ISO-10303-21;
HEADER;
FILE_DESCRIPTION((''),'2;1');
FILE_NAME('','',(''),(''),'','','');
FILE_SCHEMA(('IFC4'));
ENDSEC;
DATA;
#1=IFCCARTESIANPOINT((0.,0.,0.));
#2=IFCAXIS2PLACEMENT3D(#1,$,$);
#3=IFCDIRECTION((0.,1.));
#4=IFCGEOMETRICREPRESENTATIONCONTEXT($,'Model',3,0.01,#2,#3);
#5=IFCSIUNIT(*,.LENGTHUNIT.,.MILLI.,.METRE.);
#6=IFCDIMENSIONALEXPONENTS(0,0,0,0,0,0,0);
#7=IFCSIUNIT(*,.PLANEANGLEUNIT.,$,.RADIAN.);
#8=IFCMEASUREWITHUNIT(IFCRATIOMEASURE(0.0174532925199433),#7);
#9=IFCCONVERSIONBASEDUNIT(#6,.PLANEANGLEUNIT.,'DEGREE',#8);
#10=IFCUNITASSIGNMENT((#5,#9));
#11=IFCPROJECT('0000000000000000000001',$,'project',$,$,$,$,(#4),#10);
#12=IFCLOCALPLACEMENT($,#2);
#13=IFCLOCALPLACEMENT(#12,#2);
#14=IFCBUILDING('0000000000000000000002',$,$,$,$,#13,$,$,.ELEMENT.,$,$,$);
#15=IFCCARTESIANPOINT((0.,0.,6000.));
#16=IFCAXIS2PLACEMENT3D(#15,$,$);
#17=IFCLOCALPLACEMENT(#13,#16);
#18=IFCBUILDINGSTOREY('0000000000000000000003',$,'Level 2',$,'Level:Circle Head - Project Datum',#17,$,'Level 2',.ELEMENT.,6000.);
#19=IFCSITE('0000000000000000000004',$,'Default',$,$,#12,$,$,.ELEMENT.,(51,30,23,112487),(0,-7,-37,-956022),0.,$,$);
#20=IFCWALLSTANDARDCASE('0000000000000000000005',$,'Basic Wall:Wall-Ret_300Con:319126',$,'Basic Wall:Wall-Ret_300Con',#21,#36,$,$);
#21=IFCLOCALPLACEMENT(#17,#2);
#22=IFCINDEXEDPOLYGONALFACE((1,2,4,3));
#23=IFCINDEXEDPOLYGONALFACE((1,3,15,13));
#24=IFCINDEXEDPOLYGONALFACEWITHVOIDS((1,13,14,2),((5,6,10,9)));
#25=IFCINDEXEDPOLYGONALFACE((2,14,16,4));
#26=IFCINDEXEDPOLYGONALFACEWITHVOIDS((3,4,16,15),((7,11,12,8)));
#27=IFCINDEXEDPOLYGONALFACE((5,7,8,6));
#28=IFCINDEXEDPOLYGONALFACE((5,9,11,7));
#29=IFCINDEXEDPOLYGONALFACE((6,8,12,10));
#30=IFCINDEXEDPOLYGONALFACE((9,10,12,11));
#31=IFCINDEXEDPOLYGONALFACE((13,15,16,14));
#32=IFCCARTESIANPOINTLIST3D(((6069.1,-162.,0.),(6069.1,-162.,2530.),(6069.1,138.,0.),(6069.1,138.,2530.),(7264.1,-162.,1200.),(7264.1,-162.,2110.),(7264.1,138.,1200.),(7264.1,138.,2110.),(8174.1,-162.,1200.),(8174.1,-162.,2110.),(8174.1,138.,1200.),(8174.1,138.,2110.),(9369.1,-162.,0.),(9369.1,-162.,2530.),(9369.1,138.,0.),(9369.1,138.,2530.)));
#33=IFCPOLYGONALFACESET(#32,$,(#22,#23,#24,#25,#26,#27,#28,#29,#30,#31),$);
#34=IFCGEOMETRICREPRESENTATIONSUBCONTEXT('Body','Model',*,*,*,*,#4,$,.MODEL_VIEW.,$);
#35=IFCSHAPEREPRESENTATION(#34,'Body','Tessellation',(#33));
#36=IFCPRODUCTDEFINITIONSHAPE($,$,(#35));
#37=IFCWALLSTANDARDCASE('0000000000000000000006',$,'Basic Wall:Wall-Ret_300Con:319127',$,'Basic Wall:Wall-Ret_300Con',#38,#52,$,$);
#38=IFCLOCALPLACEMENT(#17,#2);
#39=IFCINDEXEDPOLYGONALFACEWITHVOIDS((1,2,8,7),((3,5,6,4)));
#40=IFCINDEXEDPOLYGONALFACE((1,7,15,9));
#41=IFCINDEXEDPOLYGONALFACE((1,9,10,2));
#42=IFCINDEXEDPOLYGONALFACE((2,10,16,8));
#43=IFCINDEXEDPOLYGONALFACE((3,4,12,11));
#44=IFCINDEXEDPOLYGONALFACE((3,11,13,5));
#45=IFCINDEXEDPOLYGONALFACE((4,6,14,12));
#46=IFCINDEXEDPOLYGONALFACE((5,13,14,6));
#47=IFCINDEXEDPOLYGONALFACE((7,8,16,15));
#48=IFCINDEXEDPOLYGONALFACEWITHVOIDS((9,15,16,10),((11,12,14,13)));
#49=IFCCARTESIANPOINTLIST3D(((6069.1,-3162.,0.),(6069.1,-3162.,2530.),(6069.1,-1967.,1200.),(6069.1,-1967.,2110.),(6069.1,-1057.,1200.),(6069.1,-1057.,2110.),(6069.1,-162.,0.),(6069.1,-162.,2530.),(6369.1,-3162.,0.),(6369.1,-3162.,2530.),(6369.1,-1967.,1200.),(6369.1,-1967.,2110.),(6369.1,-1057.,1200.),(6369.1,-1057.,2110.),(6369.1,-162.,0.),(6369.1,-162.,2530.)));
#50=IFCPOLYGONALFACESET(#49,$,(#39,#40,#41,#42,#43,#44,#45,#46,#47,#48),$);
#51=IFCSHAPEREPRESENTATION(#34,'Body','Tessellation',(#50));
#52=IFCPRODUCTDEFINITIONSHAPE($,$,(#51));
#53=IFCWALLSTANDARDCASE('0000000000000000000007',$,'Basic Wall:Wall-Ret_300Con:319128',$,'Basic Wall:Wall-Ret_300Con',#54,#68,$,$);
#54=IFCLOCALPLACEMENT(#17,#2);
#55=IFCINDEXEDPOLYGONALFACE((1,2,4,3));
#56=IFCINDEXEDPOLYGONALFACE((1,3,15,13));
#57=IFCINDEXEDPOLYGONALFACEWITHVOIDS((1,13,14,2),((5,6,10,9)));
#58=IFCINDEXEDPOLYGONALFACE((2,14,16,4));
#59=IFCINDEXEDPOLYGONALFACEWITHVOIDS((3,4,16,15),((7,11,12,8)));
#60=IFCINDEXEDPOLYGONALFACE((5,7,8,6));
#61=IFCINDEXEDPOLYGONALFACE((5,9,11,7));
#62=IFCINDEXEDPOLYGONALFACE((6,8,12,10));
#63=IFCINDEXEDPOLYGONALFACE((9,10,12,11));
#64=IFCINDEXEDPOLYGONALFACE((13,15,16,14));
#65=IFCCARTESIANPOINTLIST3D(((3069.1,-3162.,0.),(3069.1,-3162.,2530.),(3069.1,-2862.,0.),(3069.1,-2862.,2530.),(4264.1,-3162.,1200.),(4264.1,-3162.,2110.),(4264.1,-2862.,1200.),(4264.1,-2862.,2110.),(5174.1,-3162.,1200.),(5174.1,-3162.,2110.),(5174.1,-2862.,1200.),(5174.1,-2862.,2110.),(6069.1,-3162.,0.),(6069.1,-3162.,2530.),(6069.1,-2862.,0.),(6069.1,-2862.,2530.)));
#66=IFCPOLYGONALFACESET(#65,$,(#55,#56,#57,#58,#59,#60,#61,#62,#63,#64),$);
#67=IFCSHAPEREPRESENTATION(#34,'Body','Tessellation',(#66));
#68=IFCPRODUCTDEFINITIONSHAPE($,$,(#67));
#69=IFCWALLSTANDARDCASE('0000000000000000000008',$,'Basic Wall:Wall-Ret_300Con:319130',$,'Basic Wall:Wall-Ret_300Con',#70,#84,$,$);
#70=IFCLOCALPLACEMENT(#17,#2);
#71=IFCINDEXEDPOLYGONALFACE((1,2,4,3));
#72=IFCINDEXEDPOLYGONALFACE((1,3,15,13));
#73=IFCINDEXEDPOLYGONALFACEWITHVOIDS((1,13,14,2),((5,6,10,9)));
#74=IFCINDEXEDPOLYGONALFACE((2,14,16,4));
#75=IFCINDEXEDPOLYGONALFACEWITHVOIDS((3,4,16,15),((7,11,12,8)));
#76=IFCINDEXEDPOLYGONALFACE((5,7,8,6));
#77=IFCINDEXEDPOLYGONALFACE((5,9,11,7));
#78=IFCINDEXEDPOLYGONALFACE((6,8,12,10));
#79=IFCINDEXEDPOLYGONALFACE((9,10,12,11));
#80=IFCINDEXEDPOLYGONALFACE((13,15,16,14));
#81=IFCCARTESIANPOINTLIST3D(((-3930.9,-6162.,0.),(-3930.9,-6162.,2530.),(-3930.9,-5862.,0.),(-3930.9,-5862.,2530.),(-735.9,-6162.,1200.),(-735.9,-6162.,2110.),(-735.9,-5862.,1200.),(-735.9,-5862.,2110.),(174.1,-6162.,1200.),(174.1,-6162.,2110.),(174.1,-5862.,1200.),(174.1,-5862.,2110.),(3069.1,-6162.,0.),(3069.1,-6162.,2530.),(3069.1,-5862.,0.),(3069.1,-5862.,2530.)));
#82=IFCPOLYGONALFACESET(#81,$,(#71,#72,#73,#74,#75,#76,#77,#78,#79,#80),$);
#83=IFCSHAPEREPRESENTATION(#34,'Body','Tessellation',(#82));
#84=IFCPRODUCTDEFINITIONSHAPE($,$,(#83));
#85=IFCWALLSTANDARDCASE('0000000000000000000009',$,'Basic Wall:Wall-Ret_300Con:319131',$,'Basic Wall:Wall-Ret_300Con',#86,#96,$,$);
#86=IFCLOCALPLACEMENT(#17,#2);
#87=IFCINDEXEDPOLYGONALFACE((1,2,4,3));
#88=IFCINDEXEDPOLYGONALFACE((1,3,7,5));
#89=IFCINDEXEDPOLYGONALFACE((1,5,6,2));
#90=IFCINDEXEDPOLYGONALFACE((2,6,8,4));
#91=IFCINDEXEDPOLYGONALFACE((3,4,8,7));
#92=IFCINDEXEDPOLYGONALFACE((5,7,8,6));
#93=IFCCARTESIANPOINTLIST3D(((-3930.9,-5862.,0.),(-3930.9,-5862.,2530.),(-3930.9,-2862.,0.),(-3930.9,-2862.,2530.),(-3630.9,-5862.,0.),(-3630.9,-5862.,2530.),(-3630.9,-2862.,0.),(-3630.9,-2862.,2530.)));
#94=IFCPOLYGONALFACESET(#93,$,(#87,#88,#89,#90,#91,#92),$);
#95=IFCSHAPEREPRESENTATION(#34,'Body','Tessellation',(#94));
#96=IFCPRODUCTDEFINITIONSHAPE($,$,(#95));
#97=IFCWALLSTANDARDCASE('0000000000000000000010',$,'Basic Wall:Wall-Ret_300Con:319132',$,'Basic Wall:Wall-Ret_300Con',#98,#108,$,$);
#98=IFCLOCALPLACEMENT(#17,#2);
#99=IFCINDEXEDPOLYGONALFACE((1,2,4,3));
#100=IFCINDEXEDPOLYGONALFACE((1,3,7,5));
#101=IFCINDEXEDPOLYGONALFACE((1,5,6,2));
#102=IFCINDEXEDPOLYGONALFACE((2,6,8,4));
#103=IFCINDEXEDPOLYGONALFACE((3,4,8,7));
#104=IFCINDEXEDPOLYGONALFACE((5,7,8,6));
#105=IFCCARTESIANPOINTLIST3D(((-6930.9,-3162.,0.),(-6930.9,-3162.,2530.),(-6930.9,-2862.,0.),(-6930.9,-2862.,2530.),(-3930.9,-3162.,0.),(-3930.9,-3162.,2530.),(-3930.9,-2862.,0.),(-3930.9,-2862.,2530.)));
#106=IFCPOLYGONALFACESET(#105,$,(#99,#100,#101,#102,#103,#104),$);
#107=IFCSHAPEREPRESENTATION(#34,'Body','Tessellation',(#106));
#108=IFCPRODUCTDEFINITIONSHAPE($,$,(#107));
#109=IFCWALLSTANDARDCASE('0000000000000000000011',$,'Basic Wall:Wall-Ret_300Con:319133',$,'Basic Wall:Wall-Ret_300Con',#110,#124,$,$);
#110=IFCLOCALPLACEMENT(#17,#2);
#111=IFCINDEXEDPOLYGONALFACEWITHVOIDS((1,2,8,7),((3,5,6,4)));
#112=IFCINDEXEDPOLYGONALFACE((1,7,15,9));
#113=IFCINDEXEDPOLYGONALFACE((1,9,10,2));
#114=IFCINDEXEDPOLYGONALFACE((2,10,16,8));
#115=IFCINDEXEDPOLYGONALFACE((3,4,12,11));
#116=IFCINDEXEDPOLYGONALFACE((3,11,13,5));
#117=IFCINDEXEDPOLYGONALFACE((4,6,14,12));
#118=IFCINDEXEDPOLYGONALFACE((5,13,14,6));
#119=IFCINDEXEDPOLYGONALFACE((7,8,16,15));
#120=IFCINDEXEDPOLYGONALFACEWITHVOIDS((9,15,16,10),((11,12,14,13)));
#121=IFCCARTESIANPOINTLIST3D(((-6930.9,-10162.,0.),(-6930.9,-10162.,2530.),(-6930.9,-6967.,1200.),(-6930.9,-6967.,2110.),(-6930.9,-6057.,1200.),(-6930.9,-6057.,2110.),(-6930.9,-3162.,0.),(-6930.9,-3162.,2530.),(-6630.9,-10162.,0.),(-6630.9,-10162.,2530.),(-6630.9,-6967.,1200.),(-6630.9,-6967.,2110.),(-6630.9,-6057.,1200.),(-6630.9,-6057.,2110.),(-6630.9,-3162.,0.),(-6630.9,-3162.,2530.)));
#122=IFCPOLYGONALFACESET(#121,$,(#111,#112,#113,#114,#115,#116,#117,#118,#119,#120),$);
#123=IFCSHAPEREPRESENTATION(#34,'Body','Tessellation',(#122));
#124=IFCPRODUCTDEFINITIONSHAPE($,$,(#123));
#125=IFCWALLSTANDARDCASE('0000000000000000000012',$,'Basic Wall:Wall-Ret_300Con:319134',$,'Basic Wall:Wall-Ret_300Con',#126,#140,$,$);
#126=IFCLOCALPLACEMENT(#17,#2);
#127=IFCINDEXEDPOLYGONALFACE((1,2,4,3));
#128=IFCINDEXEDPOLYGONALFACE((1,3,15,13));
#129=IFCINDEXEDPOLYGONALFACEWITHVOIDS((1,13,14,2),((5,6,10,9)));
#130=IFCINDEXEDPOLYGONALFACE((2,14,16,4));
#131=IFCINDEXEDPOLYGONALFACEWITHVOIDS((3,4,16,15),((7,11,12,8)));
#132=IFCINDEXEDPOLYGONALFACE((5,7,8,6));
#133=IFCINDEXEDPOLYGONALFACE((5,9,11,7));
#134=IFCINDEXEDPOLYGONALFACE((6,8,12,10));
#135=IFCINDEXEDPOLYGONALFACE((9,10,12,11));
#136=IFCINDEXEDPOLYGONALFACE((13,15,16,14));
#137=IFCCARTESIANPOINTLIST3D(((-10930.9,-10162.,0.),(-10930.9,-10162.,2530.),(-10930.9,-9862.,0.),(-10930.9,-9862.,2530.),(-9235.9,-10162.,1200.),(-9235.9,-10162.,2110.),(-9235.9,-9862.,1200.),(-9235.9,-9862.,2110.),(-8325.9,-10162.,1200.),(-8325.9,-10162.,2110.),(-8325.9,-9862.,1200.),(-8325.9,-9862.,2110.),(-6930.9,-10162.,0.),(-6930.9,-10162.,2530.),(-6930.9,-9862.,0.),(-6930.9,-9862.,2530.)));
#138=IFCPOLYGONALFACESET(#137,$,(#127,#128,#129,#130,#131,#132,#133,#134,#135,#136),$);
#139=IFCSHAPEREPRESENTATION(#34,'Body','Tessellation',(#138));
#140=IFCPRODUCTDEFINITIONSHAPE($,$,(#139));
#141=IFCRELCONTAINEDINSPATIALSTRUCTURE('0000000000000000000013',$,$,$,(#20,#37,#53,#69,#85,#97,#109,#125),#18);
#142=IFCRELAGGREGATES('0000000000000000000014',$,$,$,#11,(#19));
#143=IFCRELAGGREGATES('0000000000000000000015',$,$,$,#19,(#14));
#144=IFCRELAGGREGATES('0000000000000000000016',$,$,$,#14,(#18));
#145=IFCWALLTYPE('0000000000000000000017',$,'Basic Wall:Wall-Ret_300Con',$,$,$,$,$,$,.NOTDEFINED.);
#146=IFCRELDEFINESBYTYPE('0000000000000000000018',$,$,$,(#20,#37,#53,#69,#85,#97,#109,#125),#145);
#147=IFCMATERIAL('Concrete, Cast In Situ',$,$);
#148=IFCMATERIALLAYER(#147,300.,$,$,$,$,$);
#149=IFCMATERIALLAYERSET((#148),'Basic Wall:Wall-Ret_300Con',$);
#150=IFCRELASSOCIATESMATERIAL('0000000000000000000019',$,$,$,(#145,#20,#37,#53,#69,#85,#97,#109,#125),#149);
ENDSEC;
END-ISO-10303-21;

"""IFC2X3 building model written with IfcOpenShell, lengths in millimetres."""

from ifc_helpers import new_model, entity, si_unit, converted_unit, direction, frame, frame_2d, origin, place, context, subcontext, project, spatial, polyline, rectangle, extrude, clip, bounded_halfspace, material, layer, layer_set, layer_usage, type_object, element, save


model = new_model("IFC2X3")

# Units and contexts
model_context = context("Model", 3, precision=0.01, world=origin(), true_north=direction((0.0, 1.0)))
body_context = subcontext(model_context, "Body", "Model", "MODEL_VIEW")
ifc_project = project(units=[si_unit("LENGTHUNIT", "METRE", prefix="MILLI"), converted_unit("PLANEANGLEUNIT", "DEGREE", entity("IfcRatioMeasure", 0.0174532925199433), si_unit("PLANEANGLEUNIT", "RADIAN"), dimensions=[0, 0, 0, 0, 0, 0, 0])], contexts=[model_context])

# Site, building, storey
site_placement = place(None, origin())
site = spatial("IfcSite", under=ifc_project, at=site_placement, Name="Default", CompositionType="ELEMENT", RefLatitude=(51, 30, 23, 112487), RefLongitude=(0, -7, -37, -956022), RefElevation=0.0)
building_placement = place(site_placement, origin())
building = spatial("IfcBuilding", under=site, at=building_placement, CompositionType="ELEMENT")
storey_placement = place(building_placement, frame((0.0, 0.0, 6000.0)))
storey = spatial("IfcBuildingStorey", under=building, at=storey_placement, Name="Level 2", ObjectType="Level:Circle Head - Project Datum", LongName="Level 2", CompositionType="ELEMENT", Elevation=6000.0)

# Walls, openings
ifc_material = material(Name="Concrete, Cast In Situ")
ifc_layer = layer(ifc_material, 300.0)
ifc_layer_set = layer_set([ifc_layer], Name="Basic Wall:Wall-Ret_300Con")
ifc_layer_usage_1 = layer_usage(ifc_layer_set, "AXIS2", "NEGATIVE", 150.0)
wall_type = type_object("IfcWallType", Name="Basic Wall:Wall-Ret_300Con", PredefinedType="NOTDEFINED", material=ifc_layer_set)
wall_1_placement = place(storey_placement, frame((9369.1, -12.0, 0.0), z_axis=(0.0, 0.0, 1.0), x_axis=(-1.0, 0.0, 0.0)))
wall_1 = element("IfcWallStandardCase", 1, at=wall_1_placement, inside=storey, type_object=wall_type, material=ifc_layer_usage_1, Name="Basic Wall:Wall-Ret_300Con:319126", ObjectType="Basic Wall:Wall-Ret_300Con", context=body_context, shape_type="Clipping", body=[
    clip(extrude(rectangle(XDim=3300.0, YDim=300.0, at=frame_2d((1650.0, 0.0), x_axis=(-1.0, 0.0))), origin(), (0.0, 0.0, 1.0), 2530.0), bounded_halfspace(frame((19.9, -150.0, 2530.0), z_axis=(0.0, 0.0, -1.0), x_axis=(-1.0, 0.0, 0.0)), True, frame((19.9, -150.0, 2530.0)), polyline([(0.0, 0.0), (280.1, 0.0), (3280.1, 0.0), (3280.1, 300.0), (2980.1, 300.0), (0.0, 300.0), (0.0, 0.0)]))),
])
opening_1_placement = place(wall_1_placement, frame((2105.0, 150.0, 1200.0)))
element("IfcOpeningElement", 2, at=opening_1_placement, cuts=wall_1, ObjectType="Opening", context=body_context, shape_type="SweptSolid", body=[
    extrude(rectangle(XDim=910.0, YDim=910.0, at=frame_2d((455.0, 455.0), x_axis=(-1.0, 0.0))), frame((0.0, 0.0, 0.0), z_axis=(0.0, -1.0, 0.0), x_axis=(0.0, 0.0, 1.0)), (0.0, 0.0, 1.0), 300.0),
])
ifc_layer_usage_2 = layer_usage(ifc_layer_set, "AXIS2", "NEGATIVE", 150.0)
wall_2_placement = place(storey_placement, frame((6219.1, -162.0, 0.0), z_axis=(0.0, 0.0, 1.0), x_axis=(0.0, -1.0, 0.0)))
wall_2 = element("IfcWallStandardCase", 3, at=wall_2_placement, inside=storey, type_object=wall_type, material=ifc_layer_usage_2, Name="Basic Wall:Wall-Ret_300Con:319127", ObjectType="Basic Wall:Wall-Ret_300Con", context=body_context, shape_type="Clipping", body=[
    clip(extrude(rectangle(XDim=3000.0, YDim=300.0, at=frame_2d((1500.0, 0.0), x_axis=(-1.0, 0.0))), origin(), (0.0, 0.0, 1.0), 2530.0), bounded_halfspace(frame((0.0, -150.0, 2530.0), z_axis=(0.0, 0.0, -1.0), x_axis=(0.0, 1.0, 0.0)), True, frame((0.0, -150.0, 2530.0)), polyline([(0.0, 0.0), (2700.0, 0.0), (3000.0, 0.0), (3000.0, 280.1), (5.2, 280.1), (0.0, 280.1), (0.0, 0.0)]))),
])
opening_2_placement = place(wall_2_placement, frame((1805.0, 150.0, 1200.0)))
element("IfcOpeningElement", 4, at=opening_2_placement, cuts=wall_2, ObjectType="Opening", context=body_context, shape_type="SweptSolid", body=[
    extrude(rectangle(XDim=910.0, YDim=910.0, at=frame_2d((455.0, 455.0), x_axis=(-1.0, 0.0))), frame((0.0, 0.0, 0.0), z_axis=(0.0, -1.0, 0.0), x_axis=(0.0, 0.0, 1.0)), (0.0, 0.0, 1.0), 300.0),
])
ifc_layer_usage_3 = layer_usage(ifc_layer_set, "AXIS2", "NEGATIVE", 150.0)
wall_3_placement = place(storey_placement, frame((6069.1, -3012.0, 0.0), z_axis=(0.0, 0.0, 1.0), x_axis=(-1.0, 0.0, 0.0)))
wall_3 = element("IfcWallStandardCase", 5, at=wall_3_placement, inside=storey, type_object=wall_type, material=ifc_layer_usage_3, Name="Basic Wall:Wall-Ret_300Con:319128", ObjectType="Basic Wall:Wall-Ret_300Con", context=body_context, shape_type="Clipping", body=[
    clip(extrude(rectangle(XDim=3000.0, YDim=300.0, at=frame_2d((1500.0, 0.0), x_axis=(-1.0, 0.0))), origin(), (0.0, 0.0, 1.0), 2530.0), bounded_halfspace(frame((0.0, -150.0, 2530.0), z_axis=(0.0, 0.0, -1.0), x_axis=(-1.0, 0.0, 0.0)), True, frame((0.0, -150.0, 2530.0)), polyline([(0.0, 0.0), (3000.0, 0.0), (3000.0, 300.0), (2700.0, 300.0), (0.0, 300.0), (0.0, 0.0)]))),
])
opening_3_placement = place(wall_3_placement, frame((895.0, -150.0, 1200.0)))
element("IfcOpeningElement", 6, at=opening_3_placement, cuts=wall_3, ObjectType="Opening", context=body_context, shape_type="SweptSolid", body=[
    extrude(rectangle(XDim=910.0, YDim=910.0, at=frame_2d((455.0, 455.0), x_axis=(-1.0, 0.0))), frame((0.0, 0.0, 0.0), z_axis=(0.0, 1.0, 0.0), x_axis=(0.0, 0.0, 1.0)), (0.0, 0.0, 1.0), 300.0),
])

# Wall, opening
ifc_layer_usage_4 = layer_usage(ifc_layer_set, "AXIS2", "NEGATIVE", 150.0)
wall_4_placement = place(storey_placement, frame((3069.1, -6012.0, 0.0), z_axis=(0.0, 0.0, 1.0), x_axis=(-1.0, 0.0, 0.0)))
wall_4 = element("IfcWallStandardCase", 7, at=wall_4_placement, inside=storey, type_object=wall_type, material=ifc_layer_usage_4, Name="Basic Wall:Wall-Ret_300Con:319130", ObjectType="Basic Wall:Wall-Ret_300Con", context=body_context, shape_type="Clipping", body=[
    clip(extrude(rectangle(XDim=7000.0, YDim=300.0, at=frame_2d((3500.0, 0.0), x_axis=(-1.0, 0.0))), origin(), (0.0, 0.0, 1.0), 2530.0), bounded_halfspace(frame((0.0, -150.0, 2530.0), z_axis=(0.0, 0.0, -1.0), x_axis=(-1.0, 0.0, 0.0)), True, frame((0.0, -150.0, 2530.0)), polyline([(0.0, 0.0), (6700.0, 0.0), (7000.0, 0.0), (7000.0, 300.0), (0.0, 300.0), (0.0, 0.0)]))),
])
opening_4_placement = place(wall_4_placement, frame((2895.0, -150.0, 1200.0)))
element("IfcOpeningElement", 8, at=opening_4_placement, cuts=wall_4, ObjectType="Opening", context=body_context, shape_type="SweptSolid", body=[
    extrude(rectangle(XDim=910.0, YDim=910.0, at=frame_2d((455.0, 455.0), x_axis=(-1.0, 0.0))), frame((0.0, 0.0, 0.0), z_axis=(0.0, 1.0, 0.0), x_axis=(0.0, 0.0, 1.0)), (0.0, 0.0, 1.0), 300.0),
])

# Walls
ifc_layer_usage_5 = layer_usage(ifc_layer_set, "AXIS2", "NEGATIVE", 150.0)
wall_5_placement = place(storey_placement, frame((-3780.9, -5862.0, 0.0), z_axis=(0.0, 0.0, 1.0), x_axis=(0.0, 1.0, 0.0)))
element("IfcWallStandardCase", 9, at=wall_5_placement, inside=storey, type_object=wall_type, material=ifc_layer_usage_5, Name="Basic Wall:Wall-Ret_300Con:319131", ObjectType="Basic Wall:Wall-Ret_300Con", context=body_context, shape_type="Clipping", body=[
    clip(extrude(rectangle(XDim=3000.0, YDim=300.0, at=frame_2d((1500.0, 0.0), x_axis=(-1.0, 0.0))), origin(), (0.0, 0.0, 1.0), 2530.0), bounded_halfspace(frame((0.0, -150.0, 2530.0), z_axis=(0.0, 0.0, -1.0), x_axis=(0.0, -1.0, 0.0)), True, frame((0.0, -150.0, 2530.0)), polyline([(0.0, 0.0), (3000.0, 0.0), (3000.0, 300.0), (2700.0, 300.0), (0.0, 300.0), (0.0, 0.0)]))),
])
ifc_layer_usage_6 = layer_usage(ifc_layer_set, "AXIS2", "NEGATIVE", 150.0)
wall_6_placement = place(storey_placement, frame((-3930.9, -3012.0, 0.0), z_axis=(0.0, 0.0, 1.0), x_axis=(-1.0, 0.0, 0.0)))
element("IfcWallStandardCase", 10, at=wall_6_placement, inside=storey, type_object=wall_type, material=ifc_layer_usage_6, Name="Basic Wall:Wall-Ret_300Con:319132", ObjectType="Basic Wall:Wall-Ret_300Con", context=body_context, shape_type="Clipping", body=[
    clip(extrude(rectangle(XDim=3000.0, YDim=300.0, at=frame_2d((1500.0, 0.0), x_axis=(-1.0, 0.0))), origin(), (0.0, 0.0, 1.0), 2530.0), bounded_halfspace(frame((0.0, -150.0, 2530.0), z_axis=(0.0, 0.0, -1.0), x_axis=(-1.0, 0.0, 0.0)), True, frame((0.0, -150.0, 2530.0)), polyline([(0.0, 0.0), (3000.0, 0.0), (3000.0, 300.0), (2700.0, 300.0), (0.0, 300.0), (0.0, 0.0)]))),
])

# Walls, openings
ifc_layer_usage_7 = layer_usage(ifc_layer_set, "AXIS2", "NEGATIVE", 150.0)
wall_7_placement = place(storey_placement, frame((-6780.9, -3162.0, 0.0), z_axis=(0.0, 0.0, 1.0), x_axis=(0.0, -1.0, 0.0)))
wall_7 = element("IfcWallStandardCase", 11, at=wall_7_placement, inside=storey, type_object=wall_type, material=ifc_layer_usage_7, Name="Basic Wall:Wall-Ret_300Con:319133", ObjectType="Basic Wall:Wall-Ret_300Con", context=body_context, shape_type="Clipping", body=[
    clip(extrude(rectangle(XDim=7000.0, YDim=300.0, at=frame_2d((3500.0, 0.0), x_axis=(-1.0, 0.0))), origin(), (0.0, 0.0, 1.0), 2530.0), bounded_halfspace(frame((0.0, -150.0, 2530.0), z_axis=(0.0, 0.0, -1.0), x_axis=(0.0, 1.0, 0.0)), True, frame((0.0, -150.0, 2530.0)), polyline([(0.0, 0.0), (6700.0, 0.0), (7000.0, 0.0), (7000.0, 280.1), (5.2, 280.1), (0.0, 280.1), (0.0, 0.0)]))),
])
opening_5_placement = place(wall_7_placement, frame((2895.0, -150.0, 1200.0)))
element("IfcOpeningElement", 12, at=opening_5_placement, cuts=wall_7, ObjectType="Opening", context=body_context, shape_type="SweptSolid", body=[
    extrude(rectangle(XDim=910.0, YDim=910.0, at=frame_2d((455.0, 455.0), x_axis=(-1.0, 0.0))), frame((0.0, 0.0, 0.0), z_axis=(0.0, 1.0, 0.0), x_axis=(0.0, 0.0, 1.0)), (0.0, 0.0, 1.0), 300.0),
])
ifc_layer_usage_8 = layer_usage(ifc_layer_set, "AXIS2", "NEGATIVE", 150.0)
wall_8_placement = place(storey_placement, frame((-6930.9, -10012.0, 0.0), z_axis=(0.0, 0.0, 1.0), x_axis=(-1.0, 0.0, 0.0)))
wall_8 = element("IfcWallStandardCase", 13, at=wall_8_placement, inside=storey, type_object=wall_type, material=ifc_layer_usage_8, Name="Basic Wall:Wall-Ret_300Con:319134", ObjectType="Basic Wall:Wall-Ret_300Con", context=body_context, shape_type="Clipping", body=[
    clip(extrude(rectangle(XDim=4000.0, YDim=300.0, at=frame_2d((2000.0, 0.0), x_axis=(-1.0, 0.0))), origin(), (0.0, 0.0, 1.0), 2530.0), bounded_halfspace(frame((0.0, -150.0, 2530.0), z_axis=(0.0, 0.0, -1.0), x_axis=(-1.0, 0.0, 0.0)), True, frame((0.0, -150.0, 2530.0)), polyline([(0.0, 0.0), (3700.0, 0.0), (4000.0, 0.0), (4000.0, 300.0), (0.0, 300.0), (0.0, 0.0)]))),
])
opening_6_placement = place(wall_8_placement, frame((2305.0, 150.0, 1200.0)))
element("IfcOpeningElement", 14, at=opening_6_placement, cuts=wall_8, ObjectType="Opening", context=body_context, shape_type="SweptSolid", body=[
    extrude(rectangle(XDim=910.0, YDim=910.0, at=frame_2d((455.0, 455.0), x_axis=(-1.0, 0.0))), frame((0.0, 0.0, 0.0), z_axis=(0.0, -1.0, 0.0), x_axis=(0.0, 0.0, 1.0)), (0.0, 0.0, 1.0), 300.0),
])

save(model, "model.ifc")
